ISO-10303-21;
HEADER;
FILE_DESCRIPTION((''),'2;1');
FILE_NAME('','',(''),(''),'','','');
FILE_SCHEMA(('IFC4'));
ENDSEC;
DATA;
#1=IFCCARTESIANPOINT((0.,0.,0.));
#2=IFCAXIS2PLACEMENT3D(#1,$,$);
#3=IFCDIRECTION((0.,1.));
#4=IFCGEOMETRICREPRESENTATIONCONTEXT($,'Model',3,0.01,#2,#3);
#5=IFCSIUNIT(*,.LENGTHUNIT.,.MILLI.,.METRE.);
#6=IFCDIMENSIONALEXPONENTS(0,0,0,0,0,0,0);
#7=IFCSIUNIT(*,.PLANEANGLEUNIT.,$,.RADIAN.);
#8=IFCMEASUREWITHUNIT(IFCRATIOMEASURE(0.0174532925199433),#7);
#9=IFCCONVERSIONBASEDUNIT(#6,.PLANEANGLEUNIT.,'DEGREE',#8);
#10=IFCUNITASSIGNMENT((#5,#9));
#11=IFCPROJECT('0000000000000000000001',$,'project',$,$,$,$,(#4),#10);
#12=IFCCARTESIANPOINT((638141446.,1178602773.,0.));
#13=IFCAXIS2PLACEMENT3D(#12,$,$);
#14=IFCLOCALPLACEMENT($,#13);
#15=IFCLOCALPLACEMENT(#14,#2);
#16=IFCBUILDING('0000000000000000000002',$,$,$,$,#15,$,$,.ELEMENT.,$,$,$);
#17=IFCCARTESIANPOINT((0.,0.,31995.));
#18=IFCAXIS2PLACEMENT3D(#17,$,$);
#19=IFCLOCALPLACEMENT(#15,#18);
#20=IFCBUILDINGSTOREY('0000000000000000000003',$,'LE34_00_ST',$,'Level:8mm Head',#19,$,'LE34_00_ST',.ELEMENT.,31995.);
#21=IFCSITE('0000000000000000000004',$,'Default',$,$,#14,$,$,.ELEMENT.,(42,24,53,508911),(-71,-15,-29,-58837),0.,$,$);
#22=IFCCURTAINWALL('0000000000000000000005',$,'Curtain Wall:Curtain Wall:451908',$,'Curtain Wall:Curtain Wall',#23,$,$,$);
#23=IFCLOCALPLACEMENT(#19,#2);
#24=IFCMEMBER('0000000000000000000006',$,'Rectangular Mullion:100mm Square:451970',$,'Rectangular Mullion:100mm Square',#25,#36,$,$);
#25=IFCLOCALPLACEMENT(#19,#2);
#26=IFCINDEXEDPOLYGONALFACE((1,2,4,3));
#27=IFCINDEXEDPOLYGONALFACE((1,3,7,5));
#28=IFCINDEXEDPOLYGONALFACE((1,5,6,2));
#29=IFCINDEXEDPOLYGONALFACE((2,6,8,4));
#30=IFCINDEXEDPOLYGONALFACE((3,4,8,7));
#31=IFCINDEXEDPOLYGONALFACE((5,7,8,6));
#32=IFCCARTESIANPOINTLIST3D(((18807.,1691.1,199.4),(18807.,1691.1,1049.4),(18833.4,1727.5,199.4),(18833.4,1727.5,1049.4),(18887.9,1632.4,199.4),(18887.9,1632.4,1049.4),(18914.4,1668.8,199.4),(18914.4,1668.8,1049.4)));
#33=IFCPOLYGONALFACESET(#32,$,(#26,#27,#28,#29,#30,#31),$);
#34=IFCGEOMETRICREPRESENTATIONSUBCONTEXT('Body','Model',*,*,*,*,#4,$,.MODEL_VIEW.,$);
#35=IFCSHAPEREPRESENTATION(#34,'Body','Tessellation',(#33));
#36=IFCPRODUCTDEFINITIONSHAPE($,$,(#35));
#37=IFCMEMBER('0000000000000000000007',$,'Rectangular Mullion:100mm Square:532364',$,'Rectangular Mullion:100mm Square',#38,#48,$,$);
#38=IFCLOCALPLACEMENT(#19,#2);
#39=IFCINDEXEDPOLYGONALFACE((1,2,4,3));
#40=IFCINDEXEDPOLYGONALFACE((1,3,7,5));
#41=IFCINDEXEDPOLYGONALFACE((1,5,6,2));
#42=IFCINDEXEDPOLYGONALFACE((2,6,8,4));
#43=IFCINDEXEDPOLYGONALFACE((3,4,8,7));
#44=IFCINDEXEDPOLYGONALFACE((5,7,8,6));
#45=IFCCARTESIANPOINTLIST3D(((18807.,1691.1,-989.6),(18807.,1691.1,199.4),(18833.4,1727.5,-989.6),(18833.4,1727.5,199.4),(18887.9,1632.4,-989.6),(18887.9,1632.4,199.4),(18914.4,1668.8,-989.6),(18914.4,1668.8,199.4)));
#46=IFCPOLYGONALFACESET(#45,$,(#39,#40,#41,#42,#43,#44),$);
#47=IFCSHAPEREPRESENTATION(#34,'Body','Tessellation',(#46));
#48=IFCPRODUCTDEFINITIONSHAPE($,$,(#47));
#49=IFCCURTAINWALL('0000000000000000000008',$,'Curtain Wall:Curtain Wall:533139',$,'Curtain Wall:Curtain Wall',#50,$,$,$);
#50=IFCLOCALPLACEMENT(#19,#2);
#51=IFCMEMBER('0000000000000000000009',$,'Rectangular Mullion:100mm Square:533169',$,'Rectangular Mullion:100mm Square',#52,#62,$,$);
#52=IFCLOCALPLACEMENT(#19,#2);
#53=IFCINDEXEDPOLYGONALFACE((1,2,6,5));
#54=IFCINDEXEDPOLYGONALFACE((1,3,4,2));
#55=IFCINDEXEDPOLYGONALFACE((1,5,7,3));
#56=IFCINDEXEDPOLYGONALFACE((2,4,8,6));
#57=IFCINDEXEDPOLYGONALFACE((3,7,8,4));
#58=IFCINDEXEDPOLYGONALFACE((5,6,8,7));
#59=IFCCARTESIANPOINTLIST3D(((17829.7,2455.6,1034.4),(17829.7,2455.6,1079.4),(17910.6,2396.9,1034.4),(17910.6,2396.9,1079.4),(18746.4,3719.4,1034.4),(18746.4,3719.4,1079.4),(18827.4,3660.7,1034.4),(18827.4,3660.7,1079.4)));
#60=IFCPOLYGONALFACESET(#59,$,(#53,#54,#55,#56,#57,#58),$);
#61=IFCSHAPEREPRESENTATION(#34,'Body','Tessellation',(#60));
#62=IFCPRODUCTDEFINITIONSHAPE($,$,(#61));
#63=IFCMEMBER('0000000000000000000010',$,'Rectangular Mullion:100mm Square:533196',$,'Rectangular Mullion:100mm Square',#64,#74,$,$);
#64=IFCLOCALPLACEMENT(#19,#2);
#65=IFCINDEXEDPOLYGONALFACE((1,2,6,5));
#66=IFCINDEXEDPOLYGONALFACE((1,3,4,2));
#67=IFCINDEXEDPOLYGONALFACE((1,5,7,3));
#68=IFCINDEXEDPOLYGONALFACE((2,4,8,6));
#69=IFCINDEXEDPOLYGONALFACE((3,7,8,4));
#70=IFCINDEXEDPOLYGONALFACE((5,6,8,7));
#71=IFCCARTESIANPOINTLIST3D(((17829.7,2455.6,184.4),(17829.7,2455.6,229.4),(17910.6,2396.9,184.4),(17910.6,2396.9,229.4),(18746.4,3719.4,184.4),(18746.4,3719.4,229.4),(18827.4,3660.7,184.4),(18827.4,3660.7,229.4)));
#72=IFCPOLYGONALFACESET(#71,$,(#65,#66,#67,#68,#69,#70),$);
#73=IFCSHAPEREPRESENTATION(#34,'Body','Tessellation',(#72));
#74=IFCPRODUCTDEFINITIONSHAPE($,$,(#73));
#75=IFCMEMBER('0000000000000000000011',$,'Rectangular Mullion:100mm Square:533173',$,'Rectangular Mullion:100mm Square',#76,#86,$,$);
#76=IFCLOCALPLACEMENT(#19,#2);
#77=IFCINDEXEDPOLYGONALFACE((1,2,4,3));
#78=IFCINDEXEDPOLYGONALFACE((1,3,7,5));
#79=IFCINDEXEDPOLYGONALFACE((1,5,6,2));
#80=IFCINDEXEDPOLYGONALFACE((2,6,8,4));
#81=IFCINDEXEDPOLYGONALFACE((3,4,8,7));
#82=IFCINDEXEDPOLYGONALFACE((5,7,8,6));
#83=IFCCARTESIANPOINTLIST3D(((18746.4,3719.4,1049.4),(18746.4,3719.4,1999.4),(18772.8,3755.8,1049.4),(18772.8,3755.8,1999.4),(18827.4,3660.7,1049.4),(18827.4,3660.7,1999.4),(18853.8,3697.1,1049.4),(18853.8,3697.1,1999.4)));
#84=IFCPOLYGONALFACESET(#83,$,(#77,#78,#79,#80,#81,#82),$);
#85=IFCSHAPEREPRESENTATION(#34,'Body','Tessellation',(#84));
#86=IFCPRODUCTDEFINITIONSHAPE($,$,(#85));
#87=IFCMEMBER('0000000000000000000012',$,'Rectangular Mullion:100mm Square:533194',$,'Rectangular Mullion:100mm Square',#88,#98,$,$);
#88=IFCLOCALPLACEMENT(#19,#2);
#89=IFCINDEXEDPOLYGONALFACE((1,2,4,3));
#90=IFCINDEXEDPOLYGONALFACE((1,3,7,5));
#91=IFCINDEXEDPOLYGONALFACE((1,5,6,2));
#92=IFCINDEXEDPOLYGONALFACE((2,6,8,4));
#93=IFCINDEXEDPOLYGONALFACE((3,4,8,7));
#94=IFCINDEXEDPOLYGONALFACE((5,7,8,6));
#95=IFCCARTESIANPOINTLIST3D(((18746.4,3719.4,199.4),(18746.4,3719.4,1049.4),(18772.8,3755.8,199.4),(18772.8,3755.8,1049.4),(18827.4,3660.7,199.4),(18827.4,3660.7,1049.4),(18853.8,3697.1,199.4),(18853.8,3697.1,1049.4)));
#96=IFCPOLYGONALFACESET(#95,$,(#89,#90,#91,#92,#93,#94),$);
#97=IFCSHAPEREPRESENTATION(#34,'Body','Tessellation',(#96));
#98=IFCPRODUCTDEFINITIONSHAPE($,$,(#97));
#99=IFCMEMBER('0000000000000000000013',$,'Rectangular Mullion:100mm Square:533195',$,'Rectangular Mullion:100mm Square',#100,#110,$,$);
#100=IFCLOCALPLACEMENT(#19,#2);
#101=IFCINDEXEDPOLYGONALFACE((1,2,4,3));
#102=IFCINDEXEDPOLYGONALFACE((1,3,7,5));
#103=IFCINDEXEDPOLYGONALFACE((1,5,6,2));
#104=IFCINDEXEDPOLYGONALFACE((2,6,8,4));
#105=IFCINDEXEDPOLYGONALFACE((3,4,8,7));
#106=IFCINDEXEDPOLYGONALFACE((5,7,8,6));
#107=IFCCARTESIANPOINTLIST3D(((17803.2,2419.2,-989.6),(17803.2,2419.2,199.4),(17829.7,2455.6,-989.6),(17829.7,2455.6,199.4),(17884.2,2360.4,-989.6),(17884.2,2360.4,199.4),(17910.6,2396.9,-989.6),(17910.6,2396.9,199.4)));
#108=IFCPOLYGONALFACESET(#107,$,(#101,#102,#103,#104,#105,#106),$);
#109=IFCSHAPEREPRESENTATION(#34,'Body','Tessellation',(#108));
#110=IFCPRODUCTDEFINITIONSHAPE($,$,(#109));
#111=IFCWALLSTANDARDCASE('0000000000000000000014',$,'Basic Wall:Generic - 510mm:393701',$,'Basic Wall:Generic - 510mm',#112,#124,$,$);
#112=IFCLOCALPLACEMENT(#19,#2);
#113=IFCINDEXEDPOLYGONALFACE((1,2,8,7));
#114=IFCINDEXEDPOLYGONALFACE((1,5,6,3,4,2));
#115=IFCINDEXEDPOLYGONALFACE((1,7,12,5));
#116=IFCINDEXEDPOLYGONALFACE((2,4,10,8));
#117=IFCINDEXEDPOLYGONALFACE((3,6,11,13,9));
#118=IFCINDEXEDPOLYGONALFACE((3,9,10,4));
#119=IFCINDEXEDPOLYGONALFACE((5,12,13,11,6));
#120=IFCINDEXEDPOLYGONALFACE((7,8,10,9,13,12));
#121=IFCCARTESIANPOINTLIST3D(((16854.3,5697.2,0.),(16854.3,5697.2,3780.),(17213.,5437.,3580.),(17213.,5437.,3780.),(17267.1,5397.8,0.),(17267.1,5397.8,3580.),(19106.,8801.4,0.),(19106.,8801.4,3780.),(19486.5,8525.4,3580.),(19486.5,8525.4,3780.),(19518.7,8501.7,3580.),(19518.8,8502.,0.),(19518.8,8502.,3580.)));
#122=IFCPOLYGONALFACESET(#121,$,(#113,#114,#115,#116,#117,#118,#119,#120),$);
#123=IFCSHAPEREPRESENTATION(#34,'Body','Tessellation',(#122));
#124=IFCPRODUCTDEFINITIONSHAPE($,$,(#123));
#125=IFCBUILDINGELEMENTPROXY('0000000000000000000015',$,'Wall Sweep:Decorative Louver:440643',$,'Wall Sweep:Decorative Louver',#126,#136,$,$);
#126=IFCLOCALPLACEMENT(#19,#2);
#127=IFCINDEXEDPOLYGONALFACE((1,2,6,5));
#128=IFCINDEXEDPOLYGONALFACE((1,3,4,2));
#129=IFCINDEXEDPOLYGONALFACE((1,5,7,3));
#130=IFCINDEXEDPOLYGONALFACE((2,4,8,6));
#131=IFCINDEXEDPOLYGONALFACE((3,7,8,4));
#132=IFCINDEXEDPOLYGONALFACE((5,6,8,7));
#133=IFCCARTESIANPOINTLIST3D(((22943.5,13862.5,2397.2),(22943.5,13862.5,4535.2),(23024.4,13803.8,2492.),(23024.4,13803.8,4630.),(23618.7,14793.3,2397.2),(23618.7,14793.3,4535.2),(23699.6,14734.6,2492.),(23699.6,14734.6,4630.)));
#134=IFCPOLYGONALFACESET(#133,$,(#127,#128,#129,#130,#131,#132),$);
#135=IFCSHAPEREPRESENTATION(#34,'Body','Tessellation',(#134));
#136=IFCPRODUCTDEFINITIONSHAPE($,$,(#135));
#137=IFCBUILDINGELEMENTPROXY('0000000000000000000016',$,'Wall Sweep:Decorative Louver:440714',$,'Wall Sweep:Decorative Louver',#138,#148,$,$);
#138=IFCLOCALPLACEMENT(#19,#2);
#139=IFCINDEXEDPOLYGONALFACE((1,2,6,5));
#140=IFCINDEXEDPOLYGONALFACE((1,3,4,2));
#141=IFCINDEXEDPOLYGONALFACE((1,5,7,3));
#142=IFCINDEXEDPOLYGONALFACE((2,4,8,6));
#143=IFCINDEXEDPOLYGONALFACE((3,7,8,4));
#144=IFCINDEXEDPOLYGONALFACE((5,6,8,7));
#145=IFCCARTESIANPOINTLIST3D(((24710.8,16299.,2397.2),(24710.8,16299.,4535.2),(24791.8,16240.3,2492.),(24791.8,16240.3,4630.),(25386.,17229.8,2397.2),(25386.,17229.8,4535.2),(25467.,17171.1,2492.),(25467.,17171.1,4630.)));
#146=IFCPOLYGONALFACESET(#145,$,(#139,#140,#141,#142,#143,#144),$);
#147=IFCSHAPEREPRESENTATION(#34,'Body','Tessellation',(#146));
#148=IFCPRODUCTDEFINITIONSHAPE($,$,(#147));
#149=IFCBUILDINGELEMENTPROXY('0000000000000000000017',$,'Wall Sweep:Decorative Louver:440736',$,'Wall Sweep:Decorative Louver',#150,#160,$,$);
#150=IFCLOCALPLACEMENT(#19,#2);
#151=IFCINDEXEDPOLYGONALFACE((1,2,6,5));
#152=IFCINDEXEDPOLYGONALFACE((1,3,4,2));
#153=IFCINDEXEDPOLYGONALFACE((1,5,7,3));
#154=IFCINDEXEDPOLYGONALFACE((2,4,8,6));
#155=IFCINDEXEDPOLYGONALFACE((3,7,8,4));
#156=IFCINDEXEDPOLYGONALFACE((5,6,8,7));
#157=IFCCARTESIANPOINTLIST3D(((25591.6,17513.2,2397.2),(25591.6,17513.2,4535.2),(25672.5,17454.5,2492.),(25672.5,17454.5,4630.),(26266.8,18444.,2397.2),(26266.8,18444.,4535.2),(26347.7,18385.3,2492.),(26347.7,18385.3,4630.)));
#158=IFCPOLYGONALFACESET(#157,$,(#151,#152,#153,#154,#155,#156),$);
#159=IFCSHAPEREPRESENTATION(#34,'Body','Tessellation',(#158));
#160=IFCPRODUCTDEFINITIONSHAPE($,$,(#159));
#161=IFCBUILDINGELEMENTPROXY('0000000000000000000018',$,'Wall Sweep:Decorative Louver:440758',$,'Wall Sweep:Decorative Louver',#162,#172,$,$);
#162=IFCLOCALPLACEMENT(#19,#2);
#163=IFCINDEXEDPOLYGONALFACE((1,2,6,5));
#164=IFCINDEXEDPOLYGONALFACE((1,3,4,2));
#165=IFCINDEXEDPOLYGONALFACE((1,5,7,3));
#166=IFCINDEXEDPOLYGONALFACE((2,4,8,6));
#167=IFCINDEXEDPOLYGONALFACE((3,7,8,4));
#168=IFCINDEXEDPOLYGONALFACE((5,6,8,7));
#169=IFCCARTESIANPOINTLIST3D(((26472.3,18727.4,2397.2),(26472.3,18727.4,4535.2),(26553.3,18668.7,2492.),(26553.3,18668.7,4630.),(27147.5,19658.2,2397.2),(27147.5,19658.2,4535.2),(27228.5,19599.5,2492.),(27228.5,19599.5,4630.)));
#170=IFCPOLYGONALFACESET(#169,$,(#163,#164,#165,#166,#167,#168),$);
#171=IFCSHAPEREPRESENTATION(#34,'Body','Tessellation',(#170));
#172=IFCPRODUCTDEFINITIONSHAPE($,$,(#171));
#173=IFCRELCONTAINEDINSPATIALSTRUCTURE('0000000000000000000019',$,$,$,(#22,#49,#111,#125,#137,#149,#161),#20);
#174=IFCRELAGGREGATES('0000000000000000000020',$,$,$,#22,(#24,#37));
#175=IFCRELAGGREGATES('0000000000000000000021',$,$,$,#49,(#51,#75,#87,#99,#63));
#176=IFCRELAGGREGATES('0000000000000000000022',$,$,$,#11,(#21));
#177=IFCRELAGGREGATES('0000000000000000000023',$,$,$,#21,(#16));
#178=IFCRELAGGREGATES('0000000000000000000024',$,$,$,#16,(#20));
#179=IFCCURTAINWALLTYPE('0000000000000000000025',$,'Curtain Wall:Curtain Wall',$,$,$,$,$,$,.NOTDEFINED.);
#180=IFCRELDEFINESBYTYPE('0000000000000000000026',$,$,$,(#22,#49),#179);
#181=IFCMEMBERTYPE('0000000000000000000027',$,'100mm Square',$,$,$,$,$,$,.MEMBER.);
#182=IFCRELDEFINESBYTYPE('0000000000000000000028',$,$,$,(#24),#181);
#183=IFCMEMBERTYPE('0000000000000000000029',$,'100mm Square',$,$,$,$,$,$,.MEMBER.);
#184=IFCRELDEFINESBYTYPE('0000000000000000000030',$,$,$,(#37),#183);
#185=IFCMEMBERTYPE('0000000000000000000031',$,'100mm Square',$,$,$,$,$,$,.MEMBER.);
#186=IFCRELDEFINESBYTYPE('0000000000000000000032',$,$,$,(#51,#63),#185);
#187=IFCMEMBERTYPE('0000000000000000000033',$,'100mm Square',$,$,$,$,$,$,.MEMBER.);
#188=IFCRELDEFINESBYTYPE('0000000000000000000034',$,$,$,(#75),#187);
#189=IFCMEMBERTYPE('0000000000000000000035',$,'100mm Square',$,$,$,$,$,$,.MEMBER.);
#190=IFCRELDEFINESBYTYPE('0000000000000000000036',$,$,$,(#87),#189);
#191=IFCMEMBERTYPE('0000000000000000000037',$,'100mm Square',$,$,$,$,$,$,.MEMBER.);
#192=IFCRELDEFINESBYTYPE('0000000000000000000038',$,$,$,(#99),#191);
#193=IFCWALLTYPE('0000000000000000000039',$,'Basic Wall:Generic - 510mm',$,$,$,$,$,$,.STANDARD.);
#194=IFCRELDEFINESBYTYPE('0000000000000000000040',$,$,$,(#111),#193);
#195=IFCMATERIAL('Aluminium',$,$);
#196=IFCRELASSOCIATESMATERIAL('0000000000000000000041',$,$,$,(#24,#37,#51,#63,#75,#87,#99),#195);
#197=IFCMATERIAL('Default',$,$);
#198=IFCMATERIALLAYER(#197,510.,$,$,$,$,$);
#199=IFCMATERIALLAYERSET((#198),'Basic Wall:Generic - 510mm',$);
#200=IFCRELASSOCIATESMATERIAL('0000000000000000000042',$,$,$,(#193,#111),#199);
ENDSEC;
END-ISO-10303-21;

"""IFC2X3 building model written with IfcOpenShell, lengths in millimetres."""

from ifc_helpers import new_model, entity, si_unit, converted_unit, direction, frame, frame_2d, origin, origin_2d_with_axis, place, context, subcontext, project, spatial, polyline, rectangle, outline, extrude, clip, bounded_halfspace, source, transform, mapped, material, layer, layer_set, layer_usage, type_object, type_shapes, element, aggregate, save


model = new_model("IFC2X3")

# Units and contexts
model_context = context("Model", 3, precision=0.01, world=origin(), true_north=direction((0.0, 1.0)))
body_context = subcontext(model_context, "Body", "Model", "MODEL_VIEW")
ifc_project = project(units=[si_unit("LENGTHUNIT", "METRE", prefix="MILLI"), converted_unit("PLANEANGLEUNIT", "DEGREE", entity("IfcRatioMeasure", 0.0174532925199433), si_unit("PLANEANGLEUNIT", "RADIAN"), dimensions=[0, 0, 0, 0, 0, 0, 0])], contexts=[model_context])

# Site, building, storey
site_placement = place(None, frame((638141446.0, 1178602773.0, 0.0)))
site = spatial("IfcSite", under=ifc_project, at=site_placement, Name="Default", CompositionType="ELEMENT", RefLatitude=(42, 24, 53, 508911), RefLongitude=(-71, -15, -29, -58837), RefElevation=0.0)
building_placement = place(site_placement, origin())
building = spatial("IfcBuilding", under=site, at=building_placement, CompositionType="ELEMENT")
storey_placement = place(building_placement, frame((0.0, 0.0, 31995.0)))
storey = spatial("IfcBuildingStorey", under=building, at=storey_placement, Name="LE34_00_ST", ObjectType="Level:8mm Head", LongName="LE34_00_ST", CompositionType="ELEMENT", Elevation=31995.0)

# Curtain walls, members
curtain_wall_type = type_object("IfcCurtainWallType", Name="Curtain Wall:Curtain Wall", PredefinedType="NOTDEFINED")
curtain_wall_1_placement = place(storey_placement, frame((0.0, 0.0, -31995.0)))
curtain_wall_1 = element("IfcCurtainWall", 1, at=curtain_wall_1_placement, inside=storey, type_object=curtain_wall_type, Name="Curtain Wall:Curtain Wall:451908", ObjectType="Curtain Wall:Curtain Wall")
ifc_material_1 = material(Name="Aluminium")
member_type_1 = type_object("IfcMemberType", Name="100mm Square", PredefinedType="MEMBER")
shared_shape_1 = source(origin(), body_context, "Body", "SweptSolid", [
    extrude(rectangle(XDim=100.0, YDim=45.0, at=origin_2d_with_axis()), frame((-22.5, 0.0, -850.0), z_axis=(0.0, 0.0, 1.0), x_axis=(0.0, -1.0, 0.0)), (0.0, 0.0, 1.0), 850.0),
])
type_shapes(member_type_1, [shared_shape_1])
member_1_placement = place(storey_placement, frame((18847.5, 1661.7, 1049.4), z_axis=(0.0, 0.0, 1.0), x_axis=(-0.587164, -0.809468, 0.0)))
member_1 = element("IfcMember", 2, at=member_1_placement, type_object=member_type_1, material=ifc_material_1, Name="Rectangular Mullion:100mm Square:451970", ObjectType="Rectangular Mullion:100mm Square", context=body_context, shape_type="MappedRepresentation", body=[
    mapped(shared_shape_1, transform((0.0, 0.0, 0.0), scale=1.0)),
])
member_type_2 = type_object("IfcMemberType", Name="100mm Square", PredefinedType="MEMBER")
shared_shape_2 = source(origin(), body_context, "Body", "SweptSolid", [
    extrude(rectangle(XDim=100.0, YDim=45.0, at=origin_2d_with_axis()), frame((-22.5, 0.0, -1189.0), z_axis=(0.0, 0.0, 1.0), x_axis=(0.0, -1.0, 0.0)), (0.0, 0.0, 1.0), 1189.0),
])
type_shapes(member_type_2, [shared_shape_2])
member_2_placement = place(storey_placement, frame((18847.5, 1661.7, 199.4), z_axis=(0.0, 0.0, 1.0), x_axis=(-0.587164, -0.809468, 0.0)))
member_2 = element("IfcMember", 3, at=member_2_placement, type_object=member_type_2, material=ifc_material_1, Name="Rectangular Mullion:100mm Square:532364", ObjectType="Rectangular Mullion:100mm Square", context=body_context, shape_type="MappedRepresentation", body=[
    mapped(shared_shape_2, transform((0.0, 0.0, 0.0), scale=1.0)),
])
aggregate(curtain_wall_1, [member_1, member_2])
curtain_wall_2_placement = place(storey_placement, frame((0.0, 0.0, -31995.0)))
curtain_wall_2 = element("IfcCurtainWall", 4, at=curtain_wall_2_placement, inside=storey, type_object=curtain_wall_type, Name="Curtain Wall:Curtain Wall:533139", ObjectType="Curtain Wall:Curtain Wall")
member_type_3 = type_object("IfcMemberType", Name="100mm Square", PredefinedType="MEMBER")
shared_shape_3 = source(origin(), body_context, "Body", "SweptSolid", [
    extrude(rectangle(XDim=100.0, YDim=45.0, at=origin_2d_with_axis()), frame((7.5, 0.0, -1561.3), z_axis=(0.0, 0.0, 1.0), x_axis=(0.0, -1.0, 0.0)), (0.0, 0.0, 1.0), 1561.3),
])
type_shapes(member_type_3, [shared_shape_3])
member_3_placement = place(storey_placement, frame((18786.9, 3690.0, 1049.4), z_axis=(0.587164, 0.809468, 0.0), x_axis=(0.0, 0.0, 1.0)))
member_3 = element("IfcMember", 5, at=member_3_placement, type_object=member_type_3, material=ifc_material_1, Name="Rectangular Mullion:100mm Square:533169", ObjectType="Rectangular Mullion:100mm Square", context=body_context, shape_type="MappedRepresentation", body=[
    mapped(shared_shape_3, transform((0.0, 0.0, 0.0), scale=1.0)),
])
member_4_placement = place(storey_placement, frame((18786.9, 3690.0, 199.4), z_axis=(0.587164, 0.809468, 0.0), x_axis=(0.0, 0.0, 1.0)))
member_4 = element("IfcMember", 6, at=member_4_placement, type_object=member_type_3, material=ifc_material_1, Name="Rectangular Mullion:100mm Square:533196", ObjectType="Rectangular Mullion:100mm Square", context=body_context, shape_type="MappedRepresentation", body=[
    mapped(shared_shape_3, transform((0.0, 0.0, 0.0), scale=1.0)),
])
member_type_4 = type_object("IfcMemberType", Name="100mm Square", PredefinedType="MEMBER")
shared_shape_4 = source(origin(), body_context, "Body", "SweptSolid", [
    extrude(rectangle(XDim=100.0, YDim=45.0, at=origin_2d_with_axis()), frame((-22.5, 0.0, -950.0), z_axis=(0.0, 0.0, 1.0), x_axis=(0.0, -1.0, 0.0)), (0.0, 0.0, 1.0), 950.0),
])
type_shapes(member_type_4, [shared_shape_4])
member_5_placement = place(storey_placement, frame((18813.3, 3726.5, 1049.4), z_axis=(0.0, 0.0, -1.0), x_axis=(0.587164, 0.809468, 0.0)))
member_5 = element("IfcMember", 7, at=member_5_placement, type_object=member_type_4, material=ifc_material_1, Name="Rectangular Mullion:100mm Square:533173", ObjectType="Rectangular Mullion:100mm Square", context=body_context, shape_type="MappedRepresentation", body=[
    mapped(shared_shape_4, transform((0.0, 0.0, 0.0), scale=1.0)),
])
member_type_5 = type_object("IfcMemberType", Name="100mm Square", PredefinedType="MEMBER")
shared_shape_5 = source(origin(), body_context, "Body", "SweptSolid", [
    extrude(rectangle(XDim=100.0, YDim=45.0, at=origin_2d_with_axis()), frame((-22.5, 0.0, -850.0), z_axis=(0.0, 0.0, 1.0), x_axis=(0.0, -1.0, 0.0)), (0.0, 0.0, 1.0), 850.0),
])
type_shapes(member_type_5, [shared_shape_5])
member_6_placement = place(storey_placement, frame((18813.3, 3726.5, 199.4), z_axis=(0.0, 0.0, -1.0), x_axis=(0.587164, 0.809468, 0.0)))
member_6 = element("IfcMember", 8, at=member_6_placement, type_object=member_type_5, material=ifc_material_1, Name="Rectangular Mullion:100mm Square:533194", ObjectType="Rectangular Mullion:100mm Square", context=body_context, shape_type="MappedRepresentation", body=[
    mapped(shared_shape_5, transform((0.0, 0.0, 0.0), scale=1.0)),
])
member_type_6 = type_object("IfcMemberType", Name="100mm Square", PredefinedType="MEMBER")
shared_shape_6 = source(origin(), body_context, "Body", "SweptSolid", [
    extrude(rectangle(XDim=100.0, YDim=45.0, at=origin_2d_with_axis()), frame((-22.5, 0.0, -1189.0), z_axis=(0.0, 0.0, 1.0), x_axis=(0.0, -1.0, 0.0)), (0.0, 0.0, 1.0), 1189.0),
])
type_shapes(member_type_6, [shared_shape_6])
member_7_placement = place(storey_placement, frame((17843.7, 2389.8, 199.4), z_axis=(0.0, 0.0, 1.0), x_axis=(-0.587164, -0.809468, 0.0)))
member_7 = element("IfcMember", 9, at=member_7_placement, type_object=member_type_6, material=ifc_material_1, Name="Rectangular Mullion:100mm Square:533195", ObjectType="Rectangular Mullion:100mm Square", context=body_context, shape_type="MappedRepresentation", body=[
    mapped(shared_shape_6, transform((0.0, 0.0, 0.0), scale=1.0)),
])

# Shared definitions
ifc_material_2 = material(Name="Default")

aggregate(curtain_wall_2, [member_3, member_5, member_6, member_7, member_4])

# Wall
ifc_layer_1 = layer(ifc_material_2, 510.0)
ifc_layer_set_1 = layer_set([ifc_layer_1], Name="Basic Wall:Generic - 510mm")
ifc_layer_usage_1 = layer_usage(ifc_layer_set_1, "AXIS2", "NEGATIVE", 255.0)
wall_type = type_object("IfcWallType", Name="Basic Wall:Generic - 510mm", PredefinedType="STANDARD", material=ifc_layer_set_1)
wall_placement = place(storey_placement, frame((17060.7, 5547.5, 0.0), z_axis=(0.0, 0.0, 1.0), x_axis=(0.587164, 0.809468, 0.0)))
element("IfcWallStandardCase", 10, at=wall_placement, inside=storey, type_object=wall_type, material=ifc_layer_usage_1, Name="Basic Wall:Generic - 510mm:393701", ObjectType="Basic Wall:Generic - 510mm", context=body_context, shape_type="Clipping", body=[
    clip(clip(extrude(rectangle(XDim=3834.9, YDim=510.0, at=frame_2d((1917.4, 0.0), x_axis=(-1.0, 0.0))), origin(), (0.0, 0.0, 1.0), 3780.0), bounded_halfspace(frame((3834.9, -215.0, 3580.0), z_axis=(0.0, 0.0, -1.0), x_axis=(0.0, 1.0, 0.0)), True, frame((3834.9, -215.0, 3580.0), z_axis=(0.0, 0.0, -1.0), x_axis=(0.0, 1.0, 0.0)), polyline([(0.0, 0.0), (-40.0, 0.0), (-40.0, -995.1), (-40.0, -1125.1), (-40.0, -3834.9), (26.8, -3834.9), (0.0, 0.0)]))), bounded_halfspace(frame((0.0, -188.2, 3580.0), z_axis=(0.006995, 0.999976, 0.0), x_axis=(0.0, 0.0, 1.0)), True, frame((0.0, -188.2, 3580.0), z_axis=(0.006995, 0.999976, 0.0), x_axis=(0.0, 0.0, 1.0)), polyline([(0.0, 0.0), (200.0, 0.0), (200.0, 3835.0), (0.0, 3835.0), (0.0, 0.0)]))),
])

# Building element proxies
proxy_1_placement = place(storey_placement, origin())
element("IfcBuildingElementProxy", 11, at=proxy_1_placement, inside=storey, Name="Wall Sweep:Decorative Louver:440643", ObjectType="Wall Sweep:Decorative Louver", context=body_context, shape_type="SweptSolid", body=[
    extrude(outline(polyline([(666.6, -775.8), (804.4, -775.8), (-666.6, 775.8), (-804.4, 775.8), (666.6, -775.8)])), frame((22983.9, 13833.1, 3513.6), z_axis=(0.587164, 0.809468, 0.0), x_axis=(0.58745, -0.426119, 0.687986)), (0.0, 0.0, 1.0), 1149.9),
])
proxy_2_placement = place(storey_placement, origin())
element("IfcBuildingElementProxy", 12, at=proxy_2_placement, inside=storey, Name="Wall Sweep:Decorative Louver:440714", ObjectType="Wall Sweep:Decorative Louver", context=body_context, shape_type="SweptSolid", body=[
    extrude(outline(polyline([(666.6, -775.8), (804.4, -775.8), (-666.6, 775.8), (-804.4, 775.8), (666.6, -775.8)])), frame((24751.3, 16269.6, 3513.6), z_axis=(0.587164, 0.809468, 0.0), x_axis=(0.58745, -0.426119, 0.687986)), (0.0, 0.0, 1.0), 1149.9),
])
proxy_3_placement = place(storey_placement, origin())
element("IfcBuildingElementProxy", 13, at=proxy_3_placement, inside=storey, Name="Wall Sweep:Decorative Louver:440736", ObjectType="Wall Sweep:Decorative Louver", context=body_context, shape_type="SweptSolid", body=[
    extrude(outline(polyline([(666.6, -775.8), (804.4, -775.8), (-666.6, 775.8), (-804.4, 775.8), (666.6, -775.8)])), frame((25632.0, 17483.8, 3513.6), z_axis=(0.587164, 0.809468, 0.0), x_axis=(0.58745, -0.426119, 0.687986)), (0.0, 0.0, 1.0), 1149.9),
])
proxy_4_placement = place(storey_placement, origin())
element("IfcBuildingElementProxy", 14, at=proxy_4_placement, inside=storey, Name="Wall Sweep:Decorative Louver:440758", ObjectType="Wall Sweep:Decorative Louver", context=body_context, shape_type="SweptSolid", body=[
    extrude(outline(polyline([(666.6, -775.8), (804.4, -775.8), (-666.6, 775.8), (-804.4, 775.8), (666.6, -775.8)])), frame((26512.8, 18698.0, 3513.6), z_axis=(0.587164, 0.809468, 0.0), x_axis=(0.58745, -0.426119, 0.687986)), (0.0, 0.0, 1.0), 1149.9),
])

save(model, "model.ifc")
